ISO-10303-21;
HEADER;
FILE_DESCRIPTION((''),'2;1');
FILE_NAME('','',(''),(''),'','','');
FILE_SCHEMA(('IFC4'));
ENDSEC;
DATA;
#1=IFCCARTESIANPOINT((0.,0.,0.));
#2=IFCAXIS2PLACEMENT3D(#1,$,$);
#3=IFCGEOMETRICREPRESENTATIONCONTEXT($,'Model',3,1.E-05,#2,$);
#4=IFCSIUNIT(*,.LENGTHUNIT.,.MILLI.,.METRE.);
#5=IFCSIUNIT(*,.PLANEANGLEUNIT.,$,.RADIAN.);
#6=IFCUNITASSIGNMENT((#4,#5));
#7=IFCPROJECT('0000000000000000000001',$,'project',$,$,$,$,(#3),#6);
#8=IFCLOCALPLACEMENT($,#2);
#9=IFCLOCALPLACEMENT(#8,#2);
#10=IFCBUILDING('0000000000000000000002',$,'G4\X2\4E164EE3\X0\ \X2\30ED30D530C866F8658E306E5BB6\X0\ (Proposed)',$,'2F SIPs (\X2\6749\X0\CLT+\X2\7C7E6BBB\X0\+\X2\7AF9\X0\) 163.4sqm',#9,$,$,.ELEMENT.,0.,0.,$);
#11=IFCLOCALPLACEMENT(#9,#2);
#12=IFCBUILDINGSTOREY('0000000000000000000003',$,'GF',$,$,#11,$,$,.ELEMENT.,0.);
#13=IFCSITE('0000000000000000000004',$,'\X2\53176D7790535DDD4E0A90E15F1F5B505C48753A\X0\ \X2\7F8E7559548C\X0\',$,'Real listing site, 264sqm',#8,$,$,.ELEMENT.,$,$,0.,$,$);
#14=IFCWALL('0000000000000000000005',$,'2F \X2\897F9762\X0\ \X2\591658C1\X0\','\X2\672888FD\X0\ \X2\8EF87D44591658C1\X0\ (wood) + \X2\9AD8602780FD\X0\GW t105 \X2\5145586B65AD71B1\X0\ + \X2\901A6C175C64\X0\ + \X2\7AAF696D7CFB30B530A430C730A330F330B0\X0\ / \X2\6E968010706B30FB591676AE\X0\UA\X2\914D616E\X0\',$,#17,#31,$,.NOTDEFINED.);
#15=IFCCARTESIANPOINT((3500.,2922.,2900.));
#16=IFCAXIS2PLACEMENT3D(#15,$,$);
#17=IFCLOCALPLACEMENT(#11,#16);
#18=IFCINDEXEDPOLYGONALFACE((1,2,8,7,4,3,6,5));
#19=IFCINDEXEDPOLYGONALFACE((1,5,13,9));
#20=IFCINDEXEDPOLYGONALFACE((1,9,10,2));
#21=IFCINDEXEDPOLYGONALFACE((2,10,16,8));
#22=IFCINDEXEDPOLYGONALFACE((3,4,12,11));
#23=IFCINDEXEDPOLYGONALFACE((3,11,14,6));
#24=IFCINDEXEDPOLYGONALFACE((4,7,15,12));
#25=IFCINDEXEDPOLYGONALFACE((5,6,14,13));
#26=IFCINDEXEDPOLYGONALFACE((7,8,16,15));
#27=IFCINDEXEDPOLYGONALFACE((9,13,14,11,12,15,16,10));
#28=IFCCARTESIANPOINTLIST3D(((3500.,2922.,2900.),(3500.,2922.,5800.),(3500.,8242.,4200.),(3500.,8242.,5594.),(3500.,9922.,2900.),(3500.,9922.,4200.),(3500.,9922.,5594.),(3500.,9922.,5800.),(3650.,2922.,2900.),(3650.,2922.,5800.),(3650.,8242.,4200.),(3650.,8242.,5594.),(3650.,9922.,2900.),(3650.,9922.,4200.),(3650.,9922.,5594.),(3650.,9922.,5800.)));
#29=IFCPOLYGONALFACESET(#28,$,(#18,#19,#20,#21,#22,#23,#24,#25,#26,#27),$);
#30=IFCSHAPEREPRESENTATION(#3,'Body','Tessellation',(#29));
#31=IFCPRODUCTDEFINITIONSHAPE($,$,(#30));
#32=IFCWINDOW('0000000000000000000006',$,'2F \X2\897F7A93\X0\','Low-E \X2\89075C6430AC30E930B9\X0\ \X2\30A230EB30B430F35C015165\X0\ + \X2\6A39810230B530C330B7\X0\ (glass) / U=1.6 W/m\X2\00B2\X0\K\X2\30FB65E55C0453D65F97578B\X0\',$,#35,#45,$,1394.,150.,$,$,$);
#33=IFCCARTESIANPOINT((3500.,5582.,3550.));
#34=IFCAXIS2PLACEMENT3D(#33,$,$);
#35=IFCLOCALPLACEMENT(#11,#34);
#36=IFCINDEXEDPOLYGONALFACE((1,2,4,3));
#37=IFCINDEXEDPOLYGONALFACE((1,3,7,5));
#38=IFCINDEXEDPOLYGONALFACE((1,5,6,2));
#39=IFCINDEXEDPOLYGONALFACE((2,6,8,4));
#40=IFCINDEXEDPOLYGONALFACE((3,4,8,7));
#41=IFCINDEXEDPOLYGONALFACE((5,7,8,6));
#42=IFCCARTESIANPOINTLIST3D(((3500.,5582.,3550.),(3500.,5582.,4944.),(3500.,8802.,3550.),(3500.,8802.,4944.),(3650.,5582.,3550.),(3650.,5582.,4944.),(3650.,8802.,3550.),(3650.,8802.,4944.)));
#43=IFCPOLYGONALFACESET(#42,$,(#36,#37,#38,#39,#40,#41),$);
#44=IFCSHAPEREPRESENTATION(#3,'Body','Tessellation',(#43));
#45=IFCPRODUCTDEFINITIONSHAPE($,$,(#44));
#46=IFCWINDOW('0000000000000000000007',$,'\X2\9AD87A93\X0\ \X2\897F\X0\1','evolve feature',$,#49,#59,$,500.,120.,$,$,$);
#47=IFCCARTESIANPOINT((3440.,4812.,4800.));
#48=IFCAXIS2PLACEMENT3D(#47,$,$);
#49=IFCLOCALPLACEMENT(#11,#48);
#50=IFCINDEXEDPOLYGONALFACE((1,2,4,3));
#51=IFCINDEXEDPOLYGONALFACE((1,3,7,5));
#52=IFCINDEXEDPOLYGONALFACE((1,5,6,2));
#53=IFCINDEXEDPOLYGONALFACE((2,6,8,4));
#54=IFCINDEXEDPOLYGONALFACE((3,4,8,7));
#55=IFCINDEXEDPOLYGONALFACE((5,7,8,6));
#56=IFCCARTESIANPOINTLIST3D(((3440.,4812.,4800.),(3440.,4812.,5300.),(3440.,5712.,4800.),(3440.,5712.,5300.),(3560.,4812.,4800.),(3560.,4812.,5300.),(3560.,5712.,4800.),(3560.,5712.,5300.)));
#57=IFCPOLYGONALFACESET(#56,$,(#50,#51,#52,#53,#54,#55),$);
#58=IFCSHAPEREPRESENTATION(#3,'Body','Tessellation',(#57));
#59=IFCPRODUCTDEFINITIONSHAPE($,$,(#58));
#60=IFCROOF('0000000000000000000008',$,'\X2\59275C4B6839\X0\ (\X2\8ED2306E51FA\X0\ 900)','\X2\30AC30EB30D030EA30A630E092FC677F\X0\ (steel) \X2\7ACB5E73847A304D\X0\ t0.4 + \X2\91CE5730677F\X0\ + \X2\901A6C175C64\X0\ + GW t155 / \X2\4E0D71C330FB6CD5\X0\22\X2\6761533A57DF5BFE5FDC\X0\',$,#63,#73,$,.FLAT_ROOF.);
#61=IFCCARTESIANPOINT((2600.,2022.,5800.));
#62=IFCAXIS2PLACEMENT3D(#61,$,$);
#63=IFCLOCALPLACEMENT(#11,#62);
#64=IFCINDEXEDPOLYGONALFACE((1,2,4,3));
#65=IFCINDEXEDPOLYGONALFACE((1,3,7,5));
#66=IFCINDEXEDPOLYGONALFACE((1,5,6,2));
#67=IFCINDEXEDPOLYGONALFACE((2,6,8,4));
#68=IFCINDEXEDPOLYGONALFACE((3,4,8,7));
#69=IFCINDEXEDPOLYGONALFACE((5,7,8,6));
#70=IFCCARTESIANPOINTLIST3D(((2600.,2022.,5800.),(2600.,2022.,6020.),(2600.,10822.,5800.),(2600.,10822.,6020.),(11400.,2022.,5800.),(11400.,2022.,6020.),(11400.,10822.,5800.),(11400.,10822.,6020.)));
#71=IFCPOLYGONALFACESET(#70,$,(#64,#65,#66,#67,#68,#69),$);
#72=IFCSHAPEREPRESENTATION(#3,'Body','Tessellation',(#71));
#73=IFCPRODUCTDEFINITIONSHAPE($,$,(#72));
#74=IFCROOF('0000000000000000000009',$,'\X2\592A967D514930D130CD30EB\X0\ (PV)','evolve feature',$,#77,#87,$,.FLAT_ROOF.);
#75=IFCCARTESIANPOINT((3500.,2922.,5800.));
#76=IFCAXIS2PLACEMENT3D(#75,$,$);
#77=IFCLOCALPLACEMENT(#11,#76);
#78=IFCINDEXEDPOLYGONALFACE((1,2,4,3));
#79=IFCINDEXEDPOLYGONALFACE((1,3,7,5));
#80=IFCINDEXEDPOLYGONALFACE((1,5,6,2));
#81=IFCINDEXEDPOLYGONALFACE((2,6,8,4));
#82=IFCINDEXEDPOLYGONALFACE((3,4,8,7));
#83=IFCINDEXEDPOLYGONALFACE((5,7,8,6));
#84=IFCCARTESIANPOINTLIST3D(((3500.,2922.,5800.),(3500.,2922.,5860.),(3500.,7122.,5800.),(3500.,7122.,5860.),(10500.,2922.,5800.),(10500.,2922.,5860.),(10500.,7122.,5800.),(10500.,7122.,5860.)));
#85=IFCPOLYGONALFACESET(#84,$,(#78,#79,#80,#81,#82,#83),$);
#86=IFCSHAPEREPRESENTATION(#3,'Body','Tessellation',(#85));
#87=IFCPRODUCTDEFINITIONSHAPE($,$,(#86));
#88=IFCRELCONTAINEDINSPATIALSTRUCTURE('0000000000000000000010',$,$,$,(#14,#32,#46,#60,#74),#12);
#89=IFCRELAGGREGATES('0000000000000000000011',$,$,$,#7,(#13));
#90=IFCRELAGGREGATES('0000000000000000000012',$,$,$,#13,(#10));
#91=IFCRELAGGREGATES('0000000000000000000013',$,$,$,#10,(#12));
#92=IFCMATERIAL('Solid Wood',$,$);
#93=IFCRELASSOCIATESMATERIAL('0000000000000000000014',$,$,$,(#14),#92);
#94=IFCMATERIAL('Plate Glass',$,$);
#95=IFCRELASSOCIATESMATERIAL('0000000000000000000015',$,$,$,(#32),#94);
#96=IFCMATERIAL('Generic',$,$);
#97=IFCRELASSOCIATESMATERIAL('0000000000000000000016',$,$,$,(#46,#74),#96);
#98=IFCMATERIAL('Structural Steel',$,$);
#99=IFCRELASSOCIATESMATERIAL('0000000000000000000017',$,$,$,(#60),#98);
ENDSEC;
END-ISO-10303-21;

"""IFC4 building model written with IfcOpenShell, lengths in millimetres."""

from ifc_helpers import new_model, si_unit, frame, frame_2d, origin, place, context, project, spatial, rectangle, extrude, material, element, fill, save


model = new_model("IFC4")

# Units and contexts
model_context = context("Model", 3, precision=1e-05, world=origin())
ifc_project = project(units=[si_unit("LENGTHUNIT", "METRE", prefix="MILLI"), si_unit("PLANEANGLEUNIT", "RADIAN")], contexts=[model_context])

# Site, building, storey
site_placement = place(None, origin())
site = spatial("IfcSite", under=ifc_project, at=site_placement, Name="北海道川上郡弟子屈町 美留和", ObjectType="Real listing site, 264sqm", CompositionType="ELEMENT", RefElevation=0.0)
building_placement = place(site_placement, origin())
building = spatial("IfcBuilding", under=site, at=building_placement, Name="G4世代 ロフト書斎の家 (Proposed)", ObjectType="2F SIPs (杉CLT+籾殻+竹) 163.4sqm", CompositionType="ELEMENT", ElevationOfRefHeight=0.0, ElevationOfTerrain=0.0)
storey_placement = place(building_placement, origin())
storey = spatial("IfcBuildingStorey", under=building, at=storey_placement, Name="GF", CompositionType="ELEMENT", Elevation=0.0)

# Shared definitions
ifc_material_1 = material(Name="Solid Wood")
ifc_material_2 = material(Name="Generic")

# Shared definitions
ifc_material_3 = material(Name="Plate Glass")

# Wall, openings, windows
wall_1_placement = place(storey_placement, frame((3500.0, 2922.0, 2900.0)))
wall_1 = element("IfcWall", 1, at=wall_1_placement, inside=storey, material=ifc_material_1, Name="2F 西面 外壁", Description="木製 軸組外壁 (wood) + 高性能GW t105 充填断熱 + 通気層 + 窯業系サイディング / 準耐火・外皮UA配慮", PredefinedType="NOTDEFINED", context=model_context, shape_type="SweptSolid", body=[
    extrude(rectangle(XDim=150.0, YDim=7000.0, at=frame_2d((75.0, 3500.0))), frame((3500.0, 2922.0, 2900.0)), (0.0, 0.0, 1.0), 2900.0),
])
opening_1_placement = place(storey_placement, frame((3500.0, 5582.0, 3550.0)))
opening_1 = element("IfcOpeningElement", 2, at=opening_1_placement, cuts=wall_1, PredefinedType="NOTDEFINED", context=model_context, shape_type="SweptSolid", body=[
    extrude(rectangle(XDim=150.0, YDim=3220.0, at=frame_2d((75.0, 1610.0))), frame((3500.0, 5582.0, 3550.0)), (0.0, 0.0, 1.0), 1394.0),
])
opening_2_placement = place(storey_placement, frame((3440.0, 4812.0, 4800.0)))
opening_2 = element("IfcOpeningElement", 3, at=opening_2_placement, cuts=wall_1, PredefinedType="NOTDEFINED", context=model_context, shape_type="SweptSolid", body=[
    extrude(rectangle(XDim=120.0, YDim=900.0, at=frame_2d((60.0, 450.0))), frame((3440.0, 4812.0, 4800.0)), (0.0, 0.0, 1.0), 500.0),
])
window_1_placement = place(storey_placement, frame((3500.0, 5582.0, 3550.0)))
window_1 = element("IfcWindow", 4, at=window_1_placement, inside=storey, material=ifc_material_3, Name="2F 西窓", Description="Low-E 複層ガラス アルゴン封入 + 樹脂サッシ (glass) / U=1.6 W/m²K・日射取得型", OverallHeight=1394.0, OverallWidth=150.0, context=model_context, shape_type="SweptSolid", body=[
    extrude(rectangle(XDim=150.0, YDim=3220.0, at=frame_2d((75.0, 1610.0))), frame((3500.0, 5582.0, 3550.0)), (0.0, 0.0, 1.0), 1394.0),
])
fill(opening_1, window_1)
window_2_placement = place(storey_placement, frame((3440.0, 4812.0, 4800.0)))
window_2 = element("IfcWindow", 5, at=window_2_placement, inside=storey, material=ifc_material_2, Name="高窓 西1", Description="evolve feature", OverallHeight=500.0, OverallWidth=120.0, context=model_context, shape_type="SweptSolid", body=[
    extrude(rectangle(XDim=120.0, YDim=900.0, at=frame_2d((60.0, 450.0))), frame((3440.0, 4812.0, 4800.0)), (0.0, 0.0, 1.0), 500.0),
])
fill(opening_2, window_2)

# Roofs
ifc_material_4 = material(Name="Structural Steel")
roof_1_placement = place(storey_placement, frame((2600.0, 2022.0, 5800.0)))
element("IfcRoof", 6, at=roof_1_placement, inside=storey, material=ifc_material_4, Name="大屋根 (軒の出 900)", Description="ガルバリウム鋼板 (steel) 立平葺き t0.4 + 野地板 + 通気層 + GW t155 / 不燃・法22条区域対応", PredefinedType="FLAT_ROOF", context=model_context, shape_type="SweptSolid", body=[
    extrude(rectangle(XDim=8800.0, YDim=8800.0, at=frame_2d((4400.0, 4400.0))), frame((2600.0, 2022.0, 5800.0)), (0.0, 0.0, 1.0), 220.0),
])
roof_2_placement = place(storey_placement, frame((3500.0, 2922.0, 5800.0)))
element("IfcRoof", 7, at=roof_2_placement, inside=storey, material=ifc_material_2, Name="太陽光パネル (PV)", Description="evolve feature", PredefinedType="FLAT_ROOF", context=model_context, shape_type="SweptSolid", body=[
    extrude(rectangle(XDim=7000.0, YDim=4200.0, at=frame_2d((3500.0, 2100.0))), frame((3500.0, 2922.0, 5800.0)), (0.0, 0.0, 1.0), 60.0),
])

save(model, "model.ifc")
